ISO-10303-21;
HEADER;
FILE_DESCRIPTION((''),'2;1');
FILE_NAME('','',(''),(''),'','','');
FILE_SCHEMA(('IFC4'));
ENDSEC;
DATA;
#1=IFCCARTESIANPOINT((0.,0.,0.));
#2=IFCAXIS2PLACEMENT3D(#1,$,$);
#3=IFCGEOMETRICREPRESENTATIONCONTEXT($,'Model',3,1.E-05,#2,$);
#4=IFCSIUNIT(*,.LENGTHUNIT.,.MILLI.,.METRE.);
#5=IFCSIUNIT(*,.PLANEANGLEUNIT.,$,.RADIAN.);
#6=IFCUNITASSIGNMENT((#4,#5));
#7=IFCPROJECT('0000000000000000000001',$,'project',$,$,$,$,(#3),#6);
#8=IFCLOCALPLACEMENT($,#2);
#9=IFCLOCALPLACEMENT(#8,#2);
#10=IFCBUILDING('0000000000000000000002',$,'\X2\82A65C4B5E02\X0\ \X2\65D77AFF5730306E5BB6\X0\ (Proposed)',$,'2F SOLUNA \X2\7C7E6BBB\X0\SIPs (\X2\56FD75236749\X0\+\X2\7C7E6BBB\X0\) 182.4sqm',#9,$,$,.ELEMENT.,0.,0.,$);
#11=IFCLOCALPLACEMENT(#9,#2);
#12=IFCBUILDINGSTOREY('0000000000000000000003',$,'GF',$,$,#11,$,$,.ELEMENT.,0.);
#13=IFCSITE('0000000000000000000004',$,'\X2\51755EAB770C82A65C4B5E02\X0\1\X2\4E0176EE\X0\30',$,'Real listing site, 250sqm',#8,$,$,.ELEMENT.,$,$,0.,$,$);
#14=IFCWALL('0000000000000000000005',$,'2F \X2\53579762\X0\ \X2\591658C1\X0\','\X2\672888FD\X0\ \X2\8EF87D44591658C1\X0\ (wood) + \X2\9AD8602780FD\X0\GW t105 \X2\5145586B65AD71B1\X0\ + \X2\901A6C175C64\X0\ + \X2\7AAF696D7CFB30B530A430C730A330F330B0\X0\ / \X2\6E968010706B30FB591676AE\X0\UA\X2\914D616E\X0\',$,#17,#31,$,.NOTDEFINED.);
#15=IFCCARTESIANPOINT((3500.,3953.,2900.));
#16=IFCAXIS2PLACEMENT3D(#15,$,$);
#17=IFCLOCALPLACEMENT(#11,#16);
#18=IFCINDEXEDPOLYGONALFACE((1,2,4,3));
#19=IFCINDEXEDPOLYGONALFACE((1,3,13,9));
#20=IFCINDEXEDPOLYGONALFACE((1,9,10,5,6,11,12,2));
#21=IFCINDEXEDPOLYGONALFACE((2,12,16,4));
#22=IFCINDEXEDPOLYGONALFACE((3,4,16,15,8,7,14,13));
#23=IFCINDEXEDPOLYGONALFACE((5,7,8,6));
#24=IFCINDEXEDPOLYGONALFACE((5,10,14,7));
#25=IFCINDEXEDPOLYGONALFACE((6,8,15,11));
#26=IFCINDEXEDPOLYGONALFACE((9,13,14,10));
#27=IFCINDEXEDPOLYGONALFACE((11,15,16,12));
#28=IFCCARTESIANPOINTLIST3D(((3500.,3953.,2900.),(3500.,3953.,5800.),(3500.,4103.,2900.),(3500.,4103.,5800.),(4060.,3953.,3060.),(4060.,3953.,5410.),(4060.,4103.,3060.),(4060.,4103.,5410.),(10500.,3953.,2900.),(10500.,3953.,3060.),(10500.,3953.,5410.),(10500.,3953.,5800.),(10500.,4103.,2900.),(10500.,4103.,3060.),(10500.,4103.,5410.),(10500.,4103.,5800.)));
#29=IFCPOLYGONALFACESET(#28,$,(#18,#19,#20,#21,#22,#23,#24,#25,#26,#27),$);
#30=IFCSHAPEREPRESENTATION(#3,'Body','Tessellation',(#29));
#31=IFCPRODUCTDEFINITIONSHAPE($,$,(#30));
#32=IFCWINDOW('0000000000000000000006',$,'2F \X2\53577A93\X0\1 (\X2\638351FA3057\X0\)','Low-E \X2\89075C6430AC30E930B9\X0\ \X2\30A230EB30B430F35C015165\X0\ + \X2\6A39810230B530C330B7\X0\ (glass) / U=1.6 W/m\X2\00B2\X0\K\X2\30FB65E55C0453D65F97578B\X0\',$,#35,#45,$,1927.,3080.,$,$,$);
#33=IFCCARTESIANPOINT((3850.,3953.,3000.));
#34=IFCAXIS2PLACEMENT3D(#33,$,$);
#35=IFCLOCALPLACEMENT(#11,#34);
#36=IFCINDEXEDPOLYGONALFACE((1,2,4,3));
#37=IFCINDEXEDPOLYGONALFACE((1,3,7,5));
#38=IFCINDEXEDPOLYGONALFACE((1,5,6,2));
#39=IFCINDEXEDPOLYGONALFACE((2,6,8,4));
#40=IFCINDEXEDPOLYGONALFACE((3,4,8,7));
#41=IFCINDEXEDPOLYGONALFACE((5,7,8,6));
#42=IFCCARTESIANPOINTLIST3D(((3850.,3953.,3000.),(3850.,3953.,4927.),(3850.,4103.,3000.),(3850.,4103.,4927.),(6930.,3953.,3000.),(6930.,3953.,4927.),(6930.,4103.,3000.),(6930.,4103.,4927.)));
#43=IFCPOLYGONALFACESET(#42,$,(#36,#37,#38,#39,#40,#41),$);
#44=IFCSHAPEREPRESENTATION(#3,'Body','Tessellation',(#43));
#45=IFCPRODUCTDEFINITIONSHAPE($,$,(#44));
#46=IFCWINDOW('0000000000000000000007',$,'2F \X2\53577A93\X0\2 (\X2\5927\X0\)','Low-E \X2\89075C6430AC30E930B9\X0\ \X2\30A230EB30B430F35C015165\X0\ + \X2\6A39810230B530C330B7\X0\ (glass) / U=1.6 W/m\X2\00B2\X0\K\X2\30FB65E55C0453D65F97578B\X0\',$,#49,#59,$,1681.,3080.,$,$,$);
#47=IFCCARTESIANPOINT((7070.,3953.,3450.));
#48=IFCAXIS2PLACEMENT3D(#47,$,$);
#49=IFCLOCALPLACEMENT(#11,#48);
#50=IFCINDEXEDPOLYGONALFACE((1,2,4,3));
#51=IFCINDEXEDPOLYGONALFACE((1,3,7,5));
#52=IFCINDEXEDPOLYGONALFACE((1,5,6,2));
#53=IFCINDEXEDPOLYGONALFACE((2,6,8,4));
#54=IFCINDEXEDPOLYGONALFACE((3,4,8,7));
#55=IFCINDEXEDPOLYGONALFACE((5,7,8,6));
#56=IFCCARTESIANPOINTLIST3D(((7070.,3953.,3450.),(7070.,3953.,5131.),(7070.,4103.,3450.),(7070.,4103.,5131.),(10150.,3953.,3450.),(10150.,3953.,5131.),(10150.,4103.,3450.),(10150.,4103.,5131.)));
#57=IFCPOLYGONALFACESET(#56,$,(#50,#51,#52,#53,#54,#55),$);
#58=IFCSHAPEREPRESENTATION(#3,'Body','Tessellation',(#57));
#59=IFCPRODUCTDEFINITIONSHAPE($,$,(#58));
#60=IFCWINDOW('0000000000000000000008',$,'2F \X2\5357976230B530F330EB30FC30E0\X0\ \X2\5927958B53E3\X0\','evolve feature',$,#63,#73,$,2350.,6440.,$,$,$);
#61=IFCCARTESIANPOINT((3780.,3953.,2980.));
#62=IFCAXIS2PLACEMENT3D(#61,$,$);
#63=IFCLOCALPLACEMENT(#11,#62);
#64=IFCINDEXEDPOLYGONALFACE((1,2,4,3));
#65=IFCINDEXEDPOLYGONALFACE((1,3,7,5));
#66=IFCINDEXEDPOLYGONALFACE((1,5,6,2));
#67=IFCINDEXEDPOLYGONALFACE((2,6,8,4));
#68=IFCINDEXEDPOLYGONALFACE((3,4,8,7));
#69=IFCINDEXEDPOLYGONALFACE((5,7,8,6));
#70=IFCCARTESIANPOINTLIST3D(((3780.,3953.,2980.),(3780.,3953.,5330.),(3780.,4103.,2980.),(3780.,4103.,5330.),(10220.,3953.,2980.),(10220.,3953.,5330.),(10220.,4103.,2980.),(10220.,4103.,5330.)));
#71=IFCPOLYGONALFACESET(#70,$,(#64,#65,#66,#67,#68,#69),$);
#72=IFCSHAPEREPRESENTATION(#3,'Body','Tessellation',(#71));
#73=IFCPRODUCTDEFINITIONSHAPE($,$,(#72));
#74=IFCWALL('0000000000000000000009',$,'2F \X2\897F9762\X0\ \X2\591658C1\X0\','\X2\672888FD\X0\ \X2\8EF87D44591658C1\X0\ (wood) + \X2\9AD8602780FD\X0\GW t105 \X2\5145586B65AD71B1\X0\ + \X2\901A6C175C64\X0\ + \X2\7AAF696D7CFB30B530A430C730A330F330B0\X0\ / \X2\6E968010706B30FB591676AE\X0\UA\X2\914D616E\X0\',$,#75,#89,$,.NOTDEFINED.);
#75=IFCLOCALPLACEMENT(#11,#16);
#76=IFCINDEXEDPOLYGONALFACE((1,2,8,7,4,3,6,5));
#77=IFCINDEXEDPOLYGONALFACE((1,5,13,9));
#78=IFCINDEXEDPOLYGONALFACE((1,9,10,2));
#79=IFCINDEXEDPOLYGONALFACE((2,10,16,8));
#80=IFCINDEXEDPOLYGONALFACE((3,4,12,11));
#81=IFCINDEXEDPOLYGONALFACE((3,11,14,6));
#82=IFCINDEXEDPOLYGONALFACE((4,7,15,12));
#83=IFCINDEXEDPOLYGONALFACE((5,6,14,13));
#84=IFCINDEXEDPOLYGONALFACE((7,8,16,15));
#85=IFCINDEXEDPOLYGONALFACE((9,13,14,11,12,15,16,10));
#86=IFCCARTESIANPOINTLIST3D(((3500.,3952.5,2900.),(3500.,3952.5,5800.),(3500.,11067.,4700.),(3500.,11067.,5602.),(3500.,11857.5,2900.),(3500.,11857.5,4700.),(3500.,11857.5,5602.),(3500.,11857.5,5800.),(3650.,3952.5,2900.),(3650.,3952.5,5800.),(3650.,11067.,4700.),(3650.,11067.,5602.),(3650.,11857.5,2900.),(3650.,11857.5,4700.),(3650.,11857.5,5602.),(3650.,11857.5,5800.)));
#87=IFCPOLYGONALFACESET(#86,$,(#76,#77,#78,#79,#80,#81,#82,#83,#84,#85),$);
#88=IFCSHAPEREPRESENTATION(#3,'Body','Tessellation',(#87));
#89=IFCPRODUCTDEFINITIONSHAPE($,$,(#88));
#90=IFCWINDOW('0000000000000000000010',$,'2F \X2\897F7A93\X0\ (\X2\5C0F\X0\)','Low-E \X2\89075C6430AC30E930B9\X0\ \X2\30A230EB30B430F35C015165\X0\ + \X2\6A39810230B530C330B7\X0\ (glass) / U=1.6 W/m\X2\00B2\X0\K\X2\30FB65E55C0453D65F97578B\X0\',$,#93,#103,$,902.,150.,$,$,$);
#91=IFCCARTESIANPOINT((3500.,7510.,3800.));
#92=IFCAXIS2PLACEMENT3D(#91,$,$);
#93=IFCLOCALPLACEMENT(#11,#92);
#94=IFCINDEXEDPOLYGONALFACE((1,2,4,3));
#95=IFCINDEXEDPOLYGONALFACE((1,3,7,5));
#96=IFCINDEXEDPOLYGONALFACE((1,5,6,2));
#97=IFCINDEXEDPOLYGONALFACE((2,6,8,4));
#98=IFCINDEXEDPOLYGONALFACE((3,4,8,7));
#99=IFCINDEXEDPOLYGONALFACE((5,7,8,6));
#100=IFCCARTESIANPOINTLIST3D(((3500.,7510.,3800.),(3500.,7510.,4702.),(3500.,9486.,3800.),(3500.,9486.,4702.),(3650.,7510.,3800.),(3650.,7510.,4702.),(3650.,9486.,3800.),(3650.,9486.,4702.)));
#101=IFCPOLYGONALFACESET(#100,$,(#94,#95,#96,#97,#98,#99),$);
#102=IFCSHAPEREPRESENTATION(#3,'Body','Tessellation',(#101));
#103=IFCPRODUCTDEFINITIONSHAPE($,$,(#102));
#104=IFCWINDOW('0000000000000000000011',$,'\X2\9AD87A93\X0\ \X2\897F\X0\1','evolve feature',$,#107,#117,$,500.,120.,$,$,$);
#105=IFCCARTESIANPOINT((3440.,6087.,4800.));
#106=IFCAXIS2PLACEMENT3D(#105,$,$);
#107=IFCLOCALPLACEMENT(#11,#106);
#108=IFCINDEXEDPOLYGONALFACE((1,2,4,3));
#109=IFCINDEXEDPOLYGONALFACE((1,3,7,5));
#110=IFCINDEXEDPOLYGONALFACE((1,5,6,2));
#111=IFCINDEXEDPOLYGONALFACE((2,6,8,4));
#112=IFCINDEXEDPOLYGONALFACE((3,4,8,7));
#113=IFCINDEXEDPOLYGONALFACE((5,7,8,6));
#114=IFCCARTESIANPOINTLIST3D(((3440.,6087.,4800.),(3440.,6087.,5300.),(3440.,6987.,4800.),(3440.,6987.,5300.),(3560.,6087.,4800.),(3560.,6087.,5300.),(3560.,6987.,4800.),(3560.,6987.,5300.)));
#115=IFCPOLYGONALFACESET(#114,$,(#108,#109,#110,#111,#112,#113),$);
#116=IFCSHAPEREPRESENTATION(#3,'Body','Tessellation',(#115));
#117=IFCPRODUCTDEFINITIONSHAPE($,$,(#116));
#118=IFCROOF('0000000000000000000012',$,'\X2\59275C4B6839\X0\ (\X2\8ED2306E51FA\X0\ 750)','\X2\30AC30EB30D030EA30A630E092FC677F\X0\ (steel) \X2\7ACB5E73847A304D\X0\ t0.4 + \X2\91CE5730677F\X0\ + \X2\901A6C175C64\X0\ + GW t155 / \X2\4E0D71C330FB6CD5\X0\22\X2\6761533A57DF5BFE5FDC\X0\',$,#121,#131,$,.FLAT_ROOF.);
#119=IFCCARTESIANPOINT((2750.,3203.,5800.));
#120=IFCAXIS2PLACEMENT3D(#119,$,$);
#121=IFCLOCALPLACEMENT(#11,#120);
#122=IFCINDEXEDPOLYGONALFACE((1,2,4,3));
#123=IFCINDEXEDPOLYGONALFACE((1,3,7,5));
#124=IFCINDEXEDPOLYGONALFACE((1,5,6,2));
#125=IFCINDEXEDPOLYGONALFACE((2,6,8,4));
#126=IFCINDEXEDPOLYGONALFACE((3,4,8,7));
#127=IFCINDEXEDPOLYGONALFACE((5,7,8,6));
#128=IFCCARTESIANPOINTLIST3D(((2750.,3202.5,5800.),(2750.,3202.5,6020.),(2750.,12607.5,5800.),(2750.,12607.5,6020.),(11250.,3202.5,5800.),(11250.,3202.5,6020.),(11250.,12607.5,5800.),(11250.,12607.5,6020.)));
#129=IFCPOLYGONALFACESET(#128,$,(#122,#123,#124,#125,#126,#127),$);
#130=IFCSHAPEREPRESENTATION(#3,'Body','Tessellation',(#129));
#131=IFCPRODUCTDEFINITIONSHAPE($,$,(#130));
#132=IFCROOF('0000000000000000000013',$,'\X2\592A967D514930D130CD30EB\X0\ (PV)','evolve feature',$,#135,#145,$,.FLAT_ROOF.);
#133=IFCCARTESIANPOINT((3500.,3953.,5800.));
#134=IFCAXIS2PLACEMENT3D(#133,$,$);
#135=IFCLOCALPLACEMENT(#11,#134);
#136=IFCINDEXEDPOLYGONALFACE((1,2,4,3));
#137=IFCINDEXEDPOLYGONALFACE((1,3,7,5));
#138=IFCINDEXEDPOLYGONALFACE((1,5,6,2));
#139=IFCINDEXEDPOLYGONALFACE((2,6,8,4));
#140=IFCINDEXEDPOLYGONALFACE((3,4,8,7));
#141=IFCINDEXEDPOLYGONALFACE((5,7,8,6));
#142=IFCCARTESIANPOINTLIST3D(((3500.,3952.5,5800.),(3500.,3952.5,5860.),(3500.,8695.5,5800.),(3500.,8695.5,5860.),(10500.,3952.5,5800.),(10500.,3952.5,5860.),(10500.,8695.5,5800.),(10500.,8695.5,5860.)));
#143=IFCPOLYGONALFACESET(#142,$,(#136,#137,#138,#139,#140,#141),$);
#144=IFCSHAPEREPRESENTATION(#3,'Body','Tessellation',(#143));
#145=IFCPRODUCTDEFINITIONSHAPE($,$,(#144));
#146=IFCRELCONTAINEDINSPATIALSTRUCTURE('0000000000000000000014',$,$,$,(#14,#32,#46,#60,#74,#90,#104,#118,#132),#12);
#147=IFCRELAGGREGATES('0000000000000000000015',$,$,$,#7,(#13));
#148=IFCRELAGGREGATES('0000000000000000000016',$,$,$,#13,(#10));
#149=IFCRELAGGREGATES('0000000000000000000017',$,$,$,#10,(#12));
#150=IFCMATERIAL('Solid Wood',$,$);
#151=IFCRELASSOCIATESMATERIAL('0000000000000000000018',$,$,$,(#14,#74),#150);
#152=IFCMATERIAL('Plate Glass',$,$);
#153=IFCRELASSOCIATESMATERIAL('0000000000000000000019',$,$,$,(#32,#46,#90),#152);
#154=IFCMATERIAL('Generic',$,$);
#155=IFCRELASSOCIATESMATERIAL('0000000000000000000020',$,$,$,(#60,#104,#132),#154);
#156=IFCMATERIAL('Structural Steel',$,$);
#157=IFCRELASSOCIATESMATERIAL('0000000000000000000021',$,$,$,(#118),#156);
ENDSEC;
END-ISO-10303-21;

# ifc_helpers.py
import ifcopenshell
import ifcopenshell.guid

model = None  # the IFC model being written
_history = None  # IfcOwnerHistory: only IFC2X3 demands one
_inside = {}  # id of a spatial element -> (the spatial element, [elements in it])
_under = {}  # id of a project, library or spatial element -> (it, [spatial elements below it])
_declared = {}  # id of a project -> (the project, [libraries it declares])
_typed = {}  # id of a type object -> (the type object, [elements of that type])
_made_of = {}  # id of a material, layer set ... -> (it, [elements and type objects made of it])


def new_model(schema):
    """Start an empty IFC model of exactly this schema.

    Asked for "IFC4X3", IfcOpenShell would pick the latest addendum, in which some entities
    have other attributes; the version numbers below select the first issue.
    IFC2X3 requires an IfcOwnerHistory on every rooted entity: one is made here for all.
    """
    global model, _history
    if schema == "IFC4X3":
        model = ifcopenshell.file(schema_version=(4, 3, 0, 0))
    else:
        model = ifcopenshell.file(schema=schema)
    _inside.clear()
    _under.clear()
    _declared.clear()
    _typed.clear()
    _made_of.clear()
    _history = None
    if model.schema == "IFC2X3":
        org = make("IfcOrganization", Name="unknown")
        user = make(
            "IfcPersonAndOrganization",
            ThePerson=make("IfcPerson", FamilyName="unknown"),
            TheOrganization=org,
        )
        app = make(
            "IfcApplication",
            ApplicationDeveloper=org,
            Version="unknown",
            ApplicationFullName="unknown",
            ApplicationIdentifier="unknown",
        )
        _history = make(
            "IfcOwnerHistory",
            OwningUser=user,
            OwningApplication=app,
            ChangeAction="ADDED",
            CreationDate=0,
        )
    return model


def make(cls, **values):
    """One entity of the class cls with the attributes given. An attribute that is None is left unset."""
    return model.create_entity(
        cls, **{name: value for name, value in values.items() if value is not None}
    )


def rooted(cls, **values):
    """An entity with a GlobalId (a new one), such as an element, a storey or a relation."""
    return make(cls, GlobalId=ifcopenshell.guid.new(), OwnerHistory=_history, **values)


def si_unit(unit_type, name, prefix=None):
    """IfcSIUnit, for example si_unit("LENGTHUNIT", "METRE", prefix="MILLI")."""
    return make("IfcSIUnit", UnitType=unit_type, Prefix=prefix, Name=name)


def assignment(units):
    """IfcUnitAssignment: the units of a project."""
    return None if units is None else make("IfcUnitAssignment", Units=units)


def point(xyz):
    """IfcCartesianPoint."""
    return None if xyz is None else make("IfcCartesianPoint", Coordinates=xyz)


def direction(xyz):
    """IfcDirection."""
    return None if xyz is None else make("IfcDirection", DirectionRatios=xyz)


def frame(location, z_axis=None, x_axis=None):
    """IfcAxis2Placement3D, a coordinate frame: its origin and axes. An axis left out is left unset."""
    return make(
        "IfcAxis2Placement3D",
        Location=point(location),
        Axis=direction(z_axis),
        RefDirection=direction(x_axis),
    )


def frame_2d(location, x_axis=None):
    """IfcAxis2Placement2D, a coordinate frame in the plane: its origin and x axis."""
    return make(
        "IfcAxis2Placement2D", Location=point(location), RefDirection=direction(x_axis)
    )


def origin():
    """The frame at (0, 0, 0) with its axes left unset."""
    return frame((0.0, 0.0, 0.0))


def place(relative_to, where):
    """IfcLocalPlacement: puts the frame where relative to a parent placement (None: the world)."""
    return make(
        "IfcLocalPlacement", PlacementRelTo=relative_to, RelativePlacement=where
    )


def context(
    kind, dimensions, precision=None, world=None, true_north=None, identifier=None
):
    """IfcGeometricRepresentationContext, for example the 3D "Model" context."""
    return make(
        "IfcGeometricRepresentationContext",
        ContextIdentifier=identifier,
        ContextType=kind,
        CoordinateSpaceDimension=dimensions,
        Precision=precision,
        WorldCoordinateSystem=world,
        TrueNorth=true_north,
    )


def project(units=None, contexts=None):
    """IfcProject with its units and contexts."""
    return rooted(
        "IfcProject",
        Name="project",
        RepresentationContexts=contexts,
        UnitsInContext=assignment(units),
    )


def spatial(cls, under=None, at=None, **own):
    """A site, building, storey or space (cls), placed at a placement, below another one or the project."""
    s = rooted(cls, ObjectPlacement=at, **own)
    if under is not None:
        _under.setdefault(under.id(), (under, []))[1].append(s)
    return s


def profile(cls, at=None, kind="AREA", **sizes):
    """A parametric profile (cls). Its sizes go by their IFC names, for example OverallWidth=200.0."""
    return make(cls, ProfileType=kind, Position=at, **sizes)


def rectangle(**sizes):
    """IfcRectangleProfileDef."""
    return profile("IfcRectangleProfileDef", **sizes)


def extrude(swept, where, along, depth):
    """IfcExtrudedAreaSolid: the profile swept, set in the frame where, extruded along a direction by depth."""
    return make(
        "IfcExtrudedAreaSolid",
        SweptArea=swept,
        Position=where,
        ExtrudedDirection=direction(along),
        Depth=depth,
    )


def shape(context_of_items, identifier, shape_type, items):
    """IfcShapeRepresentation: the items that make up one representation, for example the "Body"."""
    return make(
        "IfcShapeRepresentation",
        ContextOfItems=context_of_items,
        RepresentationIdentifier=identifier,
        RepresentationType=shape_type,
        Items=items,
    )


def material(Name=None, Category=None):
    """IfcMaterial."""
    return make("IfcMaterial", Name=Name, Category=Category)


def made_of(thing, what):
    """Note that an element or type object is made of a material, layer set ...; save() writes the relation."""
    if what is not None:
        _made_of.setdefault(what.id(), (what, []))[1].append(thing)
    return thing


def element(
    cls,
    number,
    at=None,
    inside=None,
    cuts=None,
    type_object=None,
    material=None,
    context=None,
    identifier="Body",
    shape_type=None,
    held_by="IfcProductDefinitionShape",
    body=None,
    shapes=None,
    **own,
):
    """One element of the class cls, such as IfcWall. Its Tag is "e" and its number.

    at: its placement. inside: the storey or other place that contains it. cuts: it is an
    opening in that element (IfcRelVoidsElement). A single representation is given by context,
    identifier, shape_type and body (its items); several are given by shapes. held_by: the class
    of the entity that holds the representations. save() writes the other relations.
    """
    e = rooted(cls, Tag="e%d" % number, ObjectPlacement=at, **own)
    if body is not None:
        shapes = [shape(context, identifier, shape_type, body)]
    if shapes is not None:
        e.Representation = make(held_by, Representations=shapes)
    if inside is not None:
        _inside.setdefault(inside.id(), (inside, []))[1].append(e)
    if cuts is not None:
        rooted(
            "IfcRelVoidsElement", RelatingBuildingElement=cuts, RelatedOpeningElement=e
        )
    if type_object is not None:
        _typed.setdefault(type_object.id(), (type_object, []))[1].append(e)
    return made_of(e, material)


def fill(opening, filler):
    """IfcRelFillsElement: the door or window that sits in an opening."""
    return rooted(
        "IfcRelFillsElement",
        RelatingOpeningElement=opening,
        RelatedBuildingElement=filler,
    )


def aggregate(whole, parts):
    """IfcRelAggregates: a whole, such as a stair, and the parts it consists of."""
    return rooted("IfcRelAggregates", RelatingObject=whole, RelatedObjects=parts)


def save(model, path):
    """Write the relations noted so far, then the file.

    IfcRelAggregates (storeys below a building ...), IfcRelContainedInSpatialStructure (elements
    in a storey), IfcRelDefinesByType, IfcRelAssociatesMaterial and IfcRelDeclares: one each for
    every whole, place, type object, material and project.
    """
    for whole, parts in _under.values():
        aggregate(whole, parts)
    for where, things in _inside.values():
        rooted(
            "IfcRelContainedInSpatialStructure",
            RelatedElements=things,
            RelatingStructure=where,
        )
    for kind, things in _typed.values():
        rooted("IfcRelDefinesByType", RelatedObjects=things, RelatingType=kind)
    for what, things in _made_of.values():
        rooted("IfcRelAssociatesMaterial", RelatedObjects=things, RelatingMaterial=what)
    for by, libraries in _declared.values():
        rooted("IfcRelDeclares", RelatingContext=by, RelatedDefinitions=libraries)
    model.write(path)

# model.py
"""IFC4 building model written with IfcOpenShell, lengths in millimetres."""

from ifc_helpers import new_model, si_unit, frame, frame_2d, origin, place, context, project, spatial, rectangle, extrude, material, element, fill, save


model = new_model("IFC4")

# Units and contexts
model_context = context("Model", 3, precision=1e-05, world=origin())
ifc_project = project(units=[si_unit("LENGTHUNIT", "METRE", prefix="MILLI"), si_unit("PLANEANGLEUNIT", "RADIAN")], contexts=[model_context])

# Site, building, storey
site_placement = place(None, origin())
site = spatial("IfcSite", under=ifc_project, at=site_placement, Name="兵庫県芦屋市1丁目30", ObjectType="Real listing site, 250sqm", CompositionType="ELEMENT", RefElevation=0.0)
building_placement = place(site_placement, origin())
building = spatial("IfcBuilding", under=site, at=building_placement, Name="芦屋市 旗竿地の家 (Proposed)", ObjectType="2F SOLUNA 籾殻SIPs (国産杉+籾殻) 182.4sqm", CompositionType="ELEMENT", ElevationOfRefHeight=0.0, ElevationOfTerrain=0.0)
storey_placement = place(building_placement, origin())
storey = spatial("IfcBuildingStorey", under=building, at=storey_placement, Name="GF", CompositionType="ELEMENT", Elevation=0.0)

# Shared definitions
ifc_material_1 = material(Name="Solid Wood")
ifc_material_2 = material(Name="Generic")

# Shared definitions
ifc_material_3 = material(Name="Plate Glass")

# Walls, openings, windows
wall_1_placement = place(storey_placement, frame((3500.0, 3953.0, 2900.0)))
wall_1 = element("IfcWall", 1, at=wall_1_placement, inside=storey, material=ifc_material_1, Name="2F 南面 外壁", Description="木製 軸組外壁 (wood) + 高性能GW t105 充填断熱 + 通気層 + 窯業系サイディング / 準耐火・外皮UA配慮", PredefinedType="NOTDEFINED", context=model_context, shape_type="SweptSolid", body=[
    extrude(rectangle(XDim=7000.0, YDim=150.0, at=frame_2d((3500.0, 75.0))), frame((3500.0, 3953.0, 2900.0)), (0.0, 0.0, 1.0), 2900.0),
])
opening_1_placement = place(storey_placement, frame((3850.0, 3953.0, 3000.0)))
opening_1 = element("IfcOpeningElement", 2, at=opening_1_placement, cuts=wall_1, PredefinedType="NOTDEFINED", context=model_context, shape_type="SweptSolid", body=[
    extrude(rectangle(XDim=3080.0, YDim=150.0, at=frame_2d((1540.0, 75.0))), frame((3850.0, 3953.0, 3000.0)), (0.0, 0.0, 1.0), 1927.0),
])
opening_2_placement = place(storey_placement, frame((7070.0, 3953.0, 3450.0)))
opening_2 = element("IfcOpeningElement", 3, at=opening_2_placement, cuts=wall_1, PredefinedType="NOTDEFINED", context=model_context, shape_type="SweptSolid", body=[
    extrude(rectangle(XDim=3080.0, YDim=150.0, at=frame_2d((1540.0, 75.0))), frame((7070.0, 3953.0, 3450.0)), (0.0, 0.0, 1.0), 1681.0),
])
opening_3_placement = place(storey_placement, frame((3780.0, 3953.0, 2980.0)))
opening_3 = element("IfcOpeningElement", 4, at=opening_3_placement, cuts=wall_1, PredefinedType="NOTDEFINED", context=model_context, shape_type="SweptSolid", body=[
    extrude(rectangle(XDim=6440.0, YDim=150.0, at=frame_2d((3220.0, 75.0))), frame((3780.0, 3953.0, 2980.0)), (0.0, 0.0, 1.0), 2350.0),
])
window_1_placement = place(storey_placement, frame((3850.0, 3953.0, 3000.0)))
window_1 = element("IfcWindow", 5, at=window_1_placement, inside=storey, material=ifc_material_3, Name="2F 南窓1 (掃出し)", Description="Low-E 複層ガラス アルゴン封入 + 樹脂サッシ (glass) / U=1.6 W/m²K・日射取得型", OverallHeight=1927.0, OverallWidth=3080.0, context=model_context, shape_type="SweptSolid", body=[
    extrude(rectangle(XDim=3080.0, YDim=150.0, at=frame_2d((1540.0, 75.0))), frame((3850.0, 3953.0, 3000.0)), (0.0, 0.0, 1.0), 1927.0),
])
fill(opening_1, window_1)
window_2_placement = place(storey_placement, frame((7070.0, 3953.0, 3450.0)))
window_2 = element("IfcWindow", 6, at=window_2_placement, inside=storey, material=ifc_material_3, Name="2F 南窓2 (大)", Description="Low-E 複層ガラス アルゴン封入 + 樹脂サッシ (glass) / U=1.6 W/m²K・日射取得型", OverallHeight=1681.0, OverallWidth=3080.0, context=model_context, shape_type="SweptSolid", body=[
    extrude(rectangle(XDim=3080.0, YDim=150.0, at=frame_2d((1540.0, 75.0))), frame((7070.0, 3953.0, 3450.0)), (0.0, 0.0, 1.0), 1681.0),
])
fill(opening_2, window_2)
window_3_placement = place(storey_placement, frame((3780.0, 3953.0, 2980.0)))
window_3 = element("IfcWindow", 7, at=window_3_placement, inside=storey, material=ifc_material_2, Name="2F 南面サンルーム 大開口", Description="evolve feature", OverallHeight=2350.0, OverallWidth=6440.0, context=model_context, shape_type="SweptSolid", body=[
    extrude(rectangle(XDim=6440.0, YDim=150.0, at=frame_2d((3220.0, 75.0))), frame((3780.0, 3953.0, 2980.0)), (0.0, 0.0, 1.0), 2350.0),
])
fill(opening_3, window_3)
wall_2_placement = place(storey_placement, frame((3500.0, 3953.0, 2900.0)))
wall_2 = element("IfcWall", 8, at=wall_2_placement, inside=storey, material=ifc_material_1, Name="2F 西面 外壁", Description="木製 軸組外壁 (wood) + 高性能GW t105 充填断熱 + 通気層 + 窯業系サイディング / 準耐火・外皮UA配慮", PredefinedType="NOTDEFINED", context=model_context, shape_type="SweptSolid", body=[
    extrude(rectangle(XDim=150.0, YDim=7905.0, at=frame_2d((75.0, 3952.0))), frame((3500.0, 3953.0, 2900.0)), (0.0, 0.0, 1.0), 2900.0),
])
opening_4_placement = place(storey_placement, frame((3500.0, 7510.0, 3800.0)))
opening_4 = element("IfcOpeningElement", 9, at=opening_4_placement, cuts=wall_2, PredefinedType="NOTDEFINED", context=model_context, shape_type="SweptSolid", body=[
    extrude(rectangle(XDim=150.0, YDim=1976.0, at=frame_2d((75.0, 988.0))), frame((3500.0, 7510.0, 3800.0)), (0.0, 0.0, 1.0), 902.0),
])
opening_5_placement = place(storey_placement, frame((3440.0, 6087.0, 4800.0)))
opening_5 = element("IfcOpeningElement", 10, at=opening_5_placement, cuts=wall_2, PredefinedType="NOTDEFINED", context=model_context, shape_type="SweptSolid", body=[
    extrude(rectangle(XDim=120.0, YDim=900.0, at=frame_2d((60.0, 450.0))), frame((3440.0, 6087.0, 4800.0)), (0.0, 0.0, 1.0), 500.0),
])
window_4_placement = place(storey_placement, frame((3500.0, 7510.0, 3800.0)))
window_4 = element("IfcWindow", 11, at=window_4_placement, inside=storey, material=ifc_material_3, Name="2F 西窓 (小)", Description="Low-E 複層ガラス アルゴン封入 + 樹脂サッシ (glass) / U=1.6 W/m²K・日射取得型", OverallHeight=902.0, OverallWidth=150.0, context=model_context, shape_type="SweptSolid", body=[
    extrude(rectangle(XDim=150.0, YDim=1976.0, at=frame_2d((75.0, 988.0))), frame((3500.0, 7510.0, 3800.0)), (0.0, 0.0, 1.0), 902.0),
])
fill(opening_4, window_4)
window_5_placement = place(storey_placement, frame((3440.0, 6087.0, 4800.0)))
window_5 = element("IfcWindow", 12, at=window_5_placement, inside=storey, material=ifc_material_2, Name="高窓 西1", Description="evolve feature", OverallHeight=500.0, OverallWidth=120.0, context=model_context, shape_type="SweptSolid", body=[
    extrude(rectangle(XDim=120.0, YDim=900.0, at=frame_2d((60.0, 450.0))), frame((3440.0, 6087.0, 4800.0)), (0.0, 0.0, 1.0), 500.0),
])
fill(opening_5, window_5)

# Roofs
ifc_material_4 = material(Name="Structural Steel")
roof_1_placement = place(storey_placement, frame((2750.0, 3203.0, 5800.0)))
element("IfcRoof", 13, at=roof_1_placement, inside=storey, material=ifc_material_4, Name="大屋根 (軒の出 750)", Description="ガルバリウム鋼板 (steel) 立平葺き t0.4 + 野地板 + 通気層 + GW t155 / 不燃・法22条区域対応", PredefinedType="FLAT_ROOF", context=model_context, shape_type="SweptSolid", body=[
    extrude(rectangle(XDim=8500.0, YDim=9405.0, at=frame_2d((4250.0, 4702.0))), frame((2750.0, 3203.0, 5800.0)), (0.0, 0.0, 1.0), 220.0),
])
roof_2_placement = place(storey_placement, frame((3500.0, 3953.0, 5800.0)))
element("IfcRoof", 14, at=roof_2_placement, inside=storey, material=ifc_material_2, Name="太陽光パネル (PV)", Description="evolve feature", PredefinedType="FLAT_ROOF", context=model_context, shape_type="SweptSolid", body=[
    extrude(rectangle(XDim=7000.0, YDim=4743.0, at=frame_2d((3500.0, 2371.0))), frame((3500.0, 3953.0, 5800.0)), (0.0, 0.0, 1.0), 60.0),
])

save(model, "model.ifc")
